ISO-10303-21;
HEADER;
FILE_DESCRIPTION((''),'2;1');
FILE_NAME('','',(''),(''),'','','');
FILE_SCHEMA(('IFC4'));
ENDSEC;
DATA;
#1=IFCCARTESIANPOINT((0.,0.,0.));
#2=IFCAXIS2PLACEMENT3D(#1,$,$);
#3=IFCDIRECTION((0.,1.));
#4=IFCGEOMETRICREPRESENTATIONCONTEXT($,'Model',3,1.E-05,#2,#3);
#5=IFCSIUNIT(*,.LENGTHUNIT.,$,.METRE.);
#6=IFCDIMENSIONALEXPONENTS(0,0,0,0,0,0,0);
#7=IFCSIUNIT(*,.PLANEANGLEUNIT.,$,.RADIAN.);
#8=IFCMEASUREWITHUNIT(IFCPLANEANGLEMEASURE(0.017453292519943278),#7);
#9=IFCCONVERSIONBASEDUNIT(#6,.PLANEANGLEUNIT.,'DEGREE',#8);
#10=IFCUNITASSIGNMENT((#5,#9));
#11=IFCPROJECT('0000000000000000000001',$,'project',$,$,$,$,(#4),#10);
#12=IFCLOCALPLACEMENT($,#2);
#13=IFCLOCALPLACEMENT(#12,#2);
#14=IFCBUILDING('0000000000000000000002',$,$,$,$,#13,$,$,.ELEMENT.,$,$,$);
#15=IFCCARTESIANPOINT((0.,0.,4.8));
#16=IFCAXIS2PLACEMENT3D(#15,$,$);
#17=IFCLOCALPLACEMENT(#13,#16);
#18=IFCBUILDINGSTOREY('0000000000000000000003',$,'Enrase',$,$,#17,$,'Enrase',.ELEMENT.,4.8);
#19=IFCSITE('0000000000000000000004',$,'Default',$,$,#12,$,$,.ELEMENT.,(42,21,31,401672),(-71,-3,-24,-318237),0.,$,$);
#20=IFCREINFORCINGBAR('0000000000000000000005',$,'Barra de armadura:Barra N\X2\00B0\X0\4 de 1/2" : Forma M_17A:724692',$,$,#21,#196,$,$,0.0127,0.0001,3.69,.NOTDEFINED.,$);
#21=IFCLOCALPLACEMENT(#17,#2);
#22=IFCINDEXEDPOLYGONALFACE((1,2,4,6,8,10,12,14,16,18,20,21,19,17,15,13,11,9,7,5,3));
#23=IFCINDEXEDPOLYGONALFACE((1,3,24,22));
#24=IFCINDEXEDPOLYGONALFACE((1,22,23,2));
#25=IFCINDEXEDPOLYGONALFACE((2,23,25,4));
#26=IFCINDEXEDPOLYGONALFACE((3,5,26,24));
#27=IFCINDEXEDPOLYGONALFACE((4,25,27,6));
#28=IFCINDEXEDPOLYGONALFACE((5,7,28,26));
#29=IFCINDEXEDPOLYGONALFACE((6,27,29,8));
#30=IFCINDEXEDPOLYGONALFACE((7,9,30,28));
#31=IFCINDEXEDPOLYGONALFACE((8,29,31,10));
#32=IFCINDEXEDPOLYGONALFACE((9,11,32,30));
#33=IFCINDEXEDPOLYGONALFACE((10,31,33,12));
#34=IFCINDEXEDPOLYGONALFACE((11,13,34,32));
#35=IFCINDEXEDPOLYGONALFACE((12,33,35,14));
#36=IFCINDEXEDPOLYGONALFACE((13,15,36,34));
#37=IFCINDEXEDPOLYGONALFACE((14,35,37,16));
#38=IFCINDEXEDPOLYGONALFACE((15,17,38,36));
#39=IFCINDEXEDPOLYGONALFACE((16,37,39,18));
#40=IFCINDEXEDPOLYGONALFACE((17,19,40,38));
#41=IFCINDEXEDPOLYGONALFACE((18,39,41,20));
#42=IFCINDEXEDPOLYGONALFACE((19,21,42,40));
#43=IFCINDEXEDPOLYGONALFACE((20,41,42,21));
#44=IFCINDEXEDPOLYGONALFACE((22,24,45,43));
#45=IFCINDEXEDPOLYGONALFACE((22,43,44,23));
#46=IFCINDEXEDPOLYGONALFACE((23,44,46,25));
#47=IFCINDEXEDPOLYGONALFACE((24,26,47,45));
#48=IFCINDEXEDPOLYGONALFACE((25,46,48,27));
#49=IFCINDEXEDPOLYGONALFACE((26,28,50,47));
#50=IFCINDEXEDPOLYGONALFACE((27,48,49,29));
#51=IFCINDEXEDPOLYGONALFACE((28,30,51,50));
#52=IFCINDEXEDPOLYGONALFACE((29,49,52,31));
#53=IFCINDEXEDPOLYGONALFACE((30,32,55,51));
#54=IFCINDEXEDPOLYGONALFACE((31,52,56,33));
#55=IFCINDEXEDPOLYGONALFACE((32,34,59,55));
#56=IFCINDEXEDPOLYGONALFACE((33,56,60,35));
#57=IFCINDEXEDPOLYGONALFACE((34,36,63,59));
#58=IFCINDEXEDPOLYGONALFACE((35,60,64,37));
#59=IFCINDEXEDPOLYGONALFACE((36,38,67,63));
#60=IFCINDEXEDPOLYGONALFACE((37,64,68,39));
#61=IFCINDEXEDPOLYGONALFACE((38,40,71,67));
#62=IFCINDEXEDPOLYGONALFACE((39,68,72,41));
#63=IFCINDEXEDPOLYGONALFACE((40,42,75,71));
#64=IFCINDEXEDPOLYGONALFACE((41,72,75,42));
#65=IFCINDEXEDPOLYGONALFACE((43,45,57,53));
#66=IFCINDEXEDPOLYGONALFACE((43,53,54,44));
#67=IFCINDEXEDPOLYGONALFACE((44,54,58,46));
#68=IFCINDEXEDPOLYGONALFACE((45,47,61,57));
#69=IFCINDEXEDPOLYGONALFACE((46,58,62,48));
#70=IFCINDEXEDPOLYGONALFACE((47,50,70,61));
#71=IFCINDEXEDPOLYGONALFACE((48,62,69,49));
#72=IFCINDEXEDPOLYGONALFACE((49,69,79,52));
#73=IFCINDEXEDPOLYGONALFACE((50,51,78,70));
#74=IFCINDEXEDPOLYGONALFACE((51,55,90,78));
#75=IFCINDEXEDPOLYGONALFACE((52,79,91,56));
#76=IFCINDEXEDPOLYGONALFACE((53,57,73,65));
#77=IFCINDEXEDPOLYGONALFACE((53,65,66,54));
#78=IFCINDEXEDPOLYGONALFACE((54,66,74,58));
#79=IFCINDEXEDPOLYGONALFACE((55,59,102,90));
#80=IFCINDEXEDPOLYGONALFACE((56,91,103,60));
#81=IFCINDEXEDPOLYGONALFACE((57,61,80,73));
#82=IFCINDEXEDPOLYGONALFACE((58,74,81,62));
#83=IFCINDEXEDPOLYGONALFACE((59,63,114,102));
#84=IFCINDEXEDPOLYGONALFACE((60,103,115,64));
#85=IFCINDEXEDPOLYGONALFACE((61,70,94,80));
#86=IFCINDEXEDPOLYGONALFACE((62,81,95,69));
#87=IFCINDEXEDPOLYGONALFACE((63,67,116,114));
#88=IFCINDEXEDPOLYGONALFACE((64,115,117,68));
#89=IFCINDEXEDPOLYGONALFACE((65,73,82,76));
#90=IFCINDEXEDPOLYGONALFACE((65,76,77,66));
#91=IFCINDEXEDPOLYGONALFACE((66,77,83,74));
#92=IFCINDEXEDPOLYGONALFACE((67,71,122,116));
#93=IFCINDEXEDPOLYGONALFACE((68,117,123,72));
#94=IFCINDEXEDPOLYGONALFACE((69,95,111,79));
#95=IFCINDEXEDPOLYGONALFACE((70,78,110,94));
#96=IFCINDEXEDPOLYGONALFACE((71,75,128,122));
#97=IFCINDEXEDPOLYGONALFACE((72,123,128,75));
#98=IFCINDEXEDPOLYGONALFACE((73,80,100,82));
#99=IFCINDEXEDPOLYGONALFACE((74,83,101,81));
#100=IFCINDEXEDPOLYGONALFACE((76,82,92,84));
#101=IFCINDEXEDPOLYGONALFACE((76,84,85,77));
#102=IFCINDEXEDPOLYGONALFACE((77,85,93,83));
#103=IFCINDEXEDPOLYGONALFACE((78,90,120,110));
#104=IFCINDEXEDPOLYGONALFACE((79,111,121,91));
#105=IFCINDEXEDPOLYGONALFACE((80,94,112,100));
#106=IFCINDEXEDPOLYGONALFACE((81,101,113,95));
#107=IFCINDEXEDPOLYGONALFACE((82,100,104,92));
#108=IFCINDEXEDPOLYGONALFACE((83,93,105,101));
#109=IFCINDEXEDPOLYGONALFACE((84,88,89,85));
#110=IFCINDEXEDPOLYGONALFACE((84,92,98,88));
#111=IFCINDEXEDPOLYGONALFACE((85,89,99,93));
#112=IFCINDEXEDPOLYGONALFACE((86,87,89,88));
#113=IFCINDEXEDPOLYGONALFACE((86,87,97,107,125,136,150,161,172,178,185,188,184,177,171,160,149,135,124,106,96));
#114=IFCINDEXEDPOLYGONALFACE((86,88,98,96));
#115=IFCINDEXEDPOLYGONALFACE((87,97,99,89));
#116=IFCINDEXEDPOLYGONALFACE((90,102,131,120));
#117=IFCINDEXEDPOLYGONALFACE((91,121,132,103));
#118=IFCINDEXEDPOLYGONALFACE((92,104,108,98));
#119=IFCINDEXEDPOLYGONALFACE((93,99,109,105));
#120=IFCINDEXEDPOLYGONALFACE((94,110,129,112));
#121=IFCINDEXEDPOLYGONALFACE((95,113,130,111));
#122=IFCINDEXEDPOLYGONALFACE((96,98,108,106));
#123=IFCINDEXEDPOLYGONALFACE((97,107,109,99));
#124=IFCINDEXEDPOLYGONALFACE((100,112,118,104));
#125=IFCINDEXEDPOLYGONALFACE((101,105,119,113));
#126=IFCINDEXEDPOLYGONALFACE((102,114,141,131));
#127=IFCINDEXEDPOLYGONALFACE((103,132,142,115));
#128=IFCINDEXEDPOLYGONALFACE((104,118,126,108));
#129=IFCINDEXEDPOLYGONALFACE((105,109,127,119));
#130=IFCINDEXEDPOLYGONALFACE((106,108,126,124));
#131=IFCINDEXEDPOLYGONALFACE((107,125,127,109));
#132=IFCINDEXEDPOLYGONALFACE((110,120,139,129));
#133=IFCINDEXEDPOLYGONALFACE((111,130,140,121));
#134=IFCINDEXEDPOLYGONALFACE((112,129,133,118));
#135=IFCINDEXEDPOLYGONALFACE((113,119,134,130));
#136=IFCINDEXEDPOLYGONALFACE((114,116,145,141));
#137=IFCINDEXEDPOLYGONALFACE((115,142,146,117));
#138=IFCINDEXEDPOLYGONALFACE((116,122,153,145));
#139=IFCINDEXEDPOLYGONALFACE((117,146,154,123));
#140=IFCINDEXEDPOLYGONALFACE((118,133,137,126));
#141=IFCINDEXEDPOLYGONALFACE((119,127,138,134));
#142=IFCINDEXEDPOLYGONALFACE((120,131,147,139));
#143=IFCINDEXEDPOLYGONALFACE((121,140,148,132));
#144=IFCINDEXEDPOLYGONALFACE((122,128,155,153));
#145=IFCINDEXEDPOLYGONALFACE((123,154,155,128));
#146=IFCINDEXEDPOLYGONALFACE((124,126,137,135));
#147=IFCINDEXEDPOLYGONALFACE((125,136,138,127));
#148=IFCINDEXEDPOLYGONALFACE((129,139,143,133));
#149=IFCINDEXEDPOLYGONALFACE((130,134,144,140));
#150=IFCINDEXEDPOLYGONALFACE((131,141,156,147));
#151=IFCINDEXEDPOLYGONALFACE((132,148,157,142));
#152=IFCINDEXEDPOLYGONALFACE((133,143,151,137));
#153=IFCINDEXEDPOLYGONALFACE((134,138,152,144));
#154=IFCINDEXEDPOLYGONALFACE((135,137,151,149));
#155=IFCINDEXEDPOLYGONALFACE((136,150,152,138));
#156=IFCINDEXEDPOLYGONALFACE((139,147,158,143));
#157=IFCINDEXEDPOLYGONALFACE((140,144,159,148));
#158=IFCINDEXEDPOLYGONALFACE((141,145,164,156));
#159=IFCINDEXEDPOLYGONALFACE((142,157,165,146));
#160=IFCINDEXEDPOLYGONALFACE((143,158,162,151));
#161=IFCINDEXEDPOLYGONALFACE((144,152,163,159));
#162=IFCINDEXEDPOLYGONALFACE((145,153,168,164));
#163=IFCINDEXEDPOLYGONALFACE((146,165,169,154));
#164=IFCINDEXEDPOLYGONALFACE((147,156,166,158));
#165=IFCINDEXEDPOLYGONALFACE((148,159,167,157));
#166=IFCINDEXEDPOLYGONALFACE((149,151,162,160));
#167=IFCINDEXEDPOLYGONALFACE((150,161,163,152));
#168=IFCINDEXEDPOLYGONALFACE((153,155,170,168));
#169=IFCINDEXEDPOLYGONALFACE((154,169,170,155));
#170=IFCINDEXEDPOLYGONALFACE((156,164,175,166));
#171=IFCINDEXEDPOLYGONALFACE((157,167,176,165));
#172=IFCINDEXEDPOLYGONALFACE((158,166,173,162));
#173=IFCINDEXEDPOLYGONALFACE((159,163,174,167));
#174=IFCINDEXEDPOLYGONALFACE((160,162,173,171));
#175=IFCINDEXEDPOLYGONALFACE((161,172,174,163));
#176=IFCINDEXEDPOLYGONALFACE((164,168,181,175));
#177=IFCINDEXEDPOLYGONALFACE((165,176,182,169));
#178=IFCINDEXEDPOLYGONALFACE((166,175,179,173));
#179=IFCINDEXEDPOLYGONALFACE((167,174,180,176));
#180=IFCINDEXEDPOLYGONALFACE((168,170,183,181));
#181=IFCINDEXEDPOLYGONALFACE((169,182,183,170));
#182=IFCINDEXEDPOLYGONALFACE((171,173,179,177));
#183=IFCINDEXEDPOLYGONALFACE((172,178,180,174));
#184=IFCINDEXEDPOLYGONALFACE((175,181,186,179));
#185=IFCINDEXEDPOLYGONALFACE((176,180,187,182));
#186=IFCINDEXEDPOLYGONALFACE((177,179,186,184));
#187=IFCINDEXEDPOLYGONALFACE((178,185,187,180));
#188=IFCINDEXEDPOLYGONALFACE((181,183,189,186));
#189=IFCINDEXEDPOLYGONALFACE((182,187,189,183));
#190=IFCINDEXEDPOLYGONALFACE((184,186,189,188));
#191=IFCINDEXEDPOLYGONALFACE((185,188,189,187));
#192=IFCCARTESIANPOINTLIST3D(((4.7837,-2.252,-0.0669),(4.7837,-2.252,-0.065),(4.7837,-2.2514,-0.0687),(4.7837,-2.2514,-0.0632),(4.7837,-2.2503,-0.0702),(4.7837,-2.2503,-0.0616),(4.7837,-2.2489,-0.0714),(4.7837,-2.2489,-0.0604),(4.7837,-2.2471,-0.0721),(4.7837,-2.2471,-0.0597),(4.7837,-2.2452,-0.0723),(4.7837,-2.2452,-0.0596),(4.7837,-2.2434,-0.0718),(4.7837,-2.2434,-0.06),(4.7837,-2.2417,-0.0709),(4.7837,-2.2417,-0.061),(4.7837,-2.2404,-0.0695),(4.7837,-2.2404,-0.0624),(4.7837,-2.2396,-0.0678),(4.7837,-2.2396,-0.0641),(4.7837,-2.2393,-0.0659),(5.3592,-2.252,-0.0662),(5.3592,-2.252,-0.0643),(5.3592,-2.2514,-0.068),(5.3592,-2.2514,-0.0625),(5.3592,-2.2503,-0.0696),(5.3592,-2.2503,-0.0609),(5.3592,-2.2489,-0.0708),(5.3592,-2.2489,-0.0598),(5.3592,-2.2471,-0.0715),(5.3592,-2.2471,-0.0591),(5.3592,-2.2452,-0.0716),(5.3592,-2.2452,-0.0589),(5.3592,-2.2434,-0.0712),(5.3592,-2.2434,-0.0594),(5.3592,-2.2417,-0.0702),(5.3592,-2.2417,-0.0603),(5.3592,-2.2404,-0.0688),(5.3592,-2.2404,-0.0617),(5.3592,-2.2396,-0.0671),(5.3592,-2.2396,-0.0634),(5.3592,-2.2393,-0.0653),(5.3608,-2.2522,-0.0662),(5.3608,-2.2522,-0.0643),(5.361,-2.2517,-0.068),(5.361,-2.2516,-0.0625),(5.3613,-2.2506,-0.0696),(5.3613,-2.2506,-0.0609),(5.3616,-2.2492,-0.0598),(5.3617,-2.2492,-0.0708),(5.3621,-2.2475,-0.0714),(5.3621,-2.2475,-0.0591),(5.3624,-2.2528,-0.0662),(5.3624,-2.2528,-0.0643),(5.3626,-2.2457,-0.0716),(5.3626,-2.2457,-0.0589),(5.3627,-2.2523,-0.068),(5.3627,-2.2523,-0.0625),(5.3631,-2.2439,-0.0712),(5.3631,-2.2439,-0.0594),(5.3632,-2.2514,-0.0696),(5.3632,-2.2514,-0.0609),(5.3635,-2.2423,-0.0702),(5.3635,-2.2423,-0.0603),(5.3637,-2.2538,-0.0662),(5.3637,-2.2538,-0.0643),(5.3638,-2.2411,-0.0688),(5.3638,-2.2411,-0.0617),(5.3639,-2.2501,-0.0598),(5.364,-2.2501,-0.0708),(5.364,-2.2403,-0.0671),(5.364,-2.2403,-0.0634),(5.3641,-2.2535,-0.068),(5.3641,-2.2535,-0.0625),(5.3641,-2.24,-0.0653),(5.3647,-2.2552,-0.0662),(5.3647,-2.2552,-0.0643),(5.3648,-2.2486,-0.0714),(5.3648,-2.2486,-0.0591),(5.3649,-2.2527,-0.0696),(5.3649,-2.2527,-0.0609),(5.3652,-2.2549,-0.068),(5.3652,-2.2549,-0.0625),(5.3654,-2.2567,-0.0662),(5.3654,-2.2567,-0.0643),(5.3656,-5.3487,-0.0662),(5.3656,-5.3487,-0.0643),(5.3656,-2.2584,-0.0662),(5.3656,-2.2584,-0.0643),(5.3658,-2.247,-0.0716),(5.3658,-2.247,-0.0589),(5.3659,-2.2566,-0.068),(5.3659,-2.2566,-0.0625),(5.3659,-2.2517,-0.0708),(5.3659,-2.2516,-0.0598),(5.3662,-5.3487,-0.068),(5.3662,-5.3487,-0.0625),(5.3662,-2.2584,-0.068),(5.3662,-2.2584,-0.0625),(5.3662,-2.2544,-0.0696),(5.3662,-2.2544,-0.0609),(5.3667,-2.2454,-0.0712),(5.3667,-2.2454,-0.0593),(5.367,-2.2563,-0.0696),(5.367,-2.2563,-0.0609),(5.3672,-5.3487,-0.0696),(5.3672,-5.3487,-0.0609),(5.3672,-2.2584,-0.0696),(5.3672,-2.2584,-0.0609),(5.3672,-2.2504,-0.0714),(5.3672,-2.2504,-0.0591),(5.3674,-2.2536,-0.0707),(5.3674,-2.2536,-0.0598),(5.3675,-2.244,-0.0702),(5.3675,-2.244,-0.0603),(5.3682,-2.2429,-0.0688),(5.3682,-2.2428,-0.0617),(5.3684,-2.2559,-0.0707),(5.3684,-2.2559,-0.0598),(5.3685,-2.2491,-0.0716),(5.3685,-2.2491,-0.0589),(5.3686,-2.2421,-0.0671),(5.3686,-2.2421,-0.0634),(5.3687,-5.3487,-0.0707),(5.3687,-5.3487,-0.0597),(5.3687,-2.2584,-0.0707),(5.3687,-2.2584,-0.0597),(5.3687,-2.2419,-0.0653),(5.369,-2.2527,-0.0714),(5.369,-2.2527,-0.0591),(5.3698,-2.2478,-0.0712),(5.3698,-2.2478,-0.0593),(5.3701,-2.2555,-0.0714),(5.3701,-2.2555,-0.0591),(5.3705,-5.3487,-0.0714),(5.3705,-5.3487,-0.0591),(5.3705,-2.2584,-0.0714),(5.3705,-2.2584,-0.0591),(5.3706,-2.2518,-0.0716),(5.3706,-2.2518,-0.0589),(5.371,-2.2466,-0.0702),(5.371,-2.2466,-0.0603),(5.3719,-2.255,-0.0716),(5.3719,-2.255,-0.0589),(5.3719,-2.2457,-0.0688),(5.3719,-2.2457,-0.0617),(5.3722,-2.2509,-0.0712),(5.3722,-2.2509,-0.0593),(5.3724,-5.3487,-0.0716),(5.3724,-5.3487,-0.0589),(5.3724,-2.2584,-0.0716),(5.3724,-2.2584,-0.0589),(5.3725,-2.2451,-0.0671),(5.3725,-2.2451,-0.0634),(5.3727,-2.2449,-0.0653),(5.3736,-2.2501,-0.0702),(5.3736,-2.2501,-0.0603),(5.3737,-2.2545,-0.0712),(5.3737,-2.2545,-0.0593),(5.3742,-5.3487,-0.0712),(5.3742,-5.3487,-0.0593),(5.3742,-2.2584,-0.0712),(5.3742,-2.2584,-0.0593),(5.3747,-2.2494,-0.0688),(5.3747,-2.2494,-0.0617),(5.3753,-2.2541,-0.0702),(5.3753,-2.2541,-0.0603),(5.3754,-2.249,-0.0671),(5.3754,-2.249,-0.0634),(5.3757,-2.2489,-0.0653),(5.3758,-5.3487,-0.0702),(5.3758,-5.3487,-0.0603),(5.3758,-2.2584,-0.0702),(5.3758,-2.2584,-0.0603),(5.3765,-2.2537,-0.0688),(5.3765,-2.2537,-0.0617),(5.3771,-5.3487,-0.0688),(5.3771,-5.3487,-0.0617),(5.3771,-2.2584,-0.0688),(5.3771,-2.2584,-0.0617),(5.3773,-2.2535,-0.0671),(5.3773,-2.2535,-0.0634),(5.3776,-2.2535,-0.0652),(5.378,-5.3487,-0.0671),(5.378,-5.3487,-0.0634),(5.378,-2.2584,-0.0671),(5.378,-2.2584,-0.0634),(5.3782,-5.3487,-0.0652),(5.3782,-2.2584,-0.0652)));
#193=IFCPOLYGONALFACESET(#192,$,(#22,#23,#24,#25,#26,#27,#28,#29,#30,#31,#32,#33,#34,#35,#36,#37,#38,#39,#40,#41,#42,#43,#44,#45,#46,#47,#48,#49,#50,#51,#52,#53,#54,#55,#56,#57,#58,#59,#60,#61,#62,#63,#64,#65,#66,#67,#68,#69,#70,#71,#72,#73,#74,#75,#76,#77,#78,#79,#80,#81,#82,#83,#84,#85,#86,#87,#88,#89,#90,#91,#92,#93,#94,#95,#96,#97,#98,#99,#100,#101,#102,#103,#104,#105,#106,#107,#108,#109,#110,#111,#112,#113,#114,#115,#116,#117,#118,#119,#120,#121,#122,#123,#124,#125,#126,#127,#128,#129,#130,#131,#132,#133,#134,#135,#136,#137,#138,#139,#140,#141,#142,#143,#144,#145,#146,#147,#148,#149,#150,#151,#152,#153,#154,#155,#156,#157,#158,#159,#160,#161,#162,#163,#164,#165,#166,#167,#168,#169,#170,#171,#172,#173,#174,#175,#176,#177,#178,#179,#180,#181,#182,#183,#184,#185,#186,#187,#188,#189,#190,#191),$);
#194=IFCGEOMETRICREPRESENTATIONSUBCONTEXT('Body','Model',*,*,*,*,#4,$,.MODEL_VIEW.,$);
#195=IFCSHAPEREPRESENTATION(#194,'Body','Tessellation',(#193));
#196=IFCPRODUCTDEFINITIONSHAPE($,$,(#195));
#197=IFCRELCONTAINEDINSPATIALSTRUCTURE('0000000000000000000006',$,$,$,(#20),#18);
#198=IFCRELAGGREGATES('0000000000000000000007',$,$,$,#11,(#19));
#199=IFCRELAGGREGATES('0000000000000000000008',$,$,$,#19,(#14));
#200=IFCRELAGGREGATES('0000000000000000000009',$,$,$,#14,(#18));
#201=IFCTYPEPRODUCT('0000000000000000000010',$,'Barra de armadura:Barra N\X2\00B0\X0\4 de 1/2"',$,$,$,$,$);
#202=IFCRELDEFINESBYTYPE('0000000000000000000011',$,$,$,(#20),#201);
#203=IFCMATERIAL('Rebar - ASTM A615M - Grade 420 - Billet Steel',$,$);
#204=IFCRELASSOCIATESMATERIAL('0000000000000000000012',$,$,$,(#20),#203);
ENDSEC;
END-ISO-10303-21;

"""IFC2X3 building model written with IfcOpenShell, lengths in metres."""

from ifc_helpers import new_model, entity, si_unit, converted_unit, direction, frame, origin, place, context, subcontext, project, spatial, material, type_object, element, save


model = new_model("IFC2X3")

# Units and contexts
model_context = context("Model", 3, precision=1e-05, world=origin(), true_north=direction((0.0, 1.0)))
body_context = subcontext(model_context, "Body", "Model", "MODEL_VIEW")
ifc_project = project(units=[si_unit("LENGTHUNIT", "METRE"), converted_unit("PLANEANGLEUNIT", "DEGREE", entity("IfcPlaneAngleMeasure", 0.017453292519943278), si_unit("PLANEANGLEUNIT", "RADIAN"), dimensions=[0, 0, 0, 0, 0, 0, 0])], contexts=[model_context])

# Site, building, storey
site_placement = place(None, origin())
site = spatial("IfcSite", under=ifc_project, at=site_placement, Name="Default", CompositionType="ELEMENT", RefLatitude=(42, 21, 31, 401672), RefLongitude=(-71, -3, -24, -318237), RefElevation=0.0)
building_placement = place(site_placement, origin())
building = spatial("IfcBuilding", under=site, at=building_placement, CompositionType="ELEMENT")
storey_placement = place(building_placement, frame((0.0, 0.0, 4.8)))
storey = spatial("IfcBuildingStorey", under=building, at=storey_placement, Name="Enrase", LongName="Enrase", CompositionType="ELEMENT", Elevation=4.8)

# Reinforcing bar
ifc_material = material(Name="Rebar - ASTM A615M - Grade 420 - Billet Steel")
type_product_1 = type_object("IfcTypeProduct", Name="Barra de armadura:Barra N°4 de 1/2\"")
reinforcing_bar_1_placement = place(storey_placement, origin())
element("IfcReinforcingBar", 1, at=reinforcing_bar_1_placement, inside=storey, type_object=type_product_1, material=ifc_material, Name="Barra de armadura:Barra N°4 de 1/2\" : Forma M_17A:724692", BarLength=3.69, BarRole="NOTDEFINED", CrossSectionArea=0.0001, NominalDiameter=0.0127, context=body_context, shape_type="AdvancedSweptSolid", body=[
    entity("IfcSweptDiskSolid", entity("IfcCompositeCurve", [entity("IfcCompositeCurveSegment", "CONTINUOUS", True, entity("IfcPolyline", [entity("IfcCartesianPoint", [5.3719, -5.3487, -0.0652]), entity("IfcCartesianPoint", [5.3719, -2.2584, -0.0652])])), entity("IfcCompositeCurveSegment", "CONTINUOUS", True, entity("IfcTrimmedCurve", entity("IfcCircle", entity("IfcAxis2Placement3D", entity("IfcCartesianPoint", [5.3592, -2.2584, -0.0653]), entity("IfcDirection", [-0.001144, 0.0, 0.999999]), entity("IfcDirection", [0.0, 1.0, 0.0])), 0.0127), [entity("IfcParameterValue", 270.0)], [entity("IfcParameterValue", 360.0)], True, "PARAMETER")), entity("IfcCompositeCurveSegment", "CONTINUOUS", True, entity("IfcPolyline", [entity("IfcCartesianPoint", [5.3592, -2.2457, -0.0653]), entity("IfcCartesianPoint", [4.7837, -2.2457, -0.0659])]))], False), 0.0063, None, 0.0, 92.0),
])

save(model, "model.ifc")
